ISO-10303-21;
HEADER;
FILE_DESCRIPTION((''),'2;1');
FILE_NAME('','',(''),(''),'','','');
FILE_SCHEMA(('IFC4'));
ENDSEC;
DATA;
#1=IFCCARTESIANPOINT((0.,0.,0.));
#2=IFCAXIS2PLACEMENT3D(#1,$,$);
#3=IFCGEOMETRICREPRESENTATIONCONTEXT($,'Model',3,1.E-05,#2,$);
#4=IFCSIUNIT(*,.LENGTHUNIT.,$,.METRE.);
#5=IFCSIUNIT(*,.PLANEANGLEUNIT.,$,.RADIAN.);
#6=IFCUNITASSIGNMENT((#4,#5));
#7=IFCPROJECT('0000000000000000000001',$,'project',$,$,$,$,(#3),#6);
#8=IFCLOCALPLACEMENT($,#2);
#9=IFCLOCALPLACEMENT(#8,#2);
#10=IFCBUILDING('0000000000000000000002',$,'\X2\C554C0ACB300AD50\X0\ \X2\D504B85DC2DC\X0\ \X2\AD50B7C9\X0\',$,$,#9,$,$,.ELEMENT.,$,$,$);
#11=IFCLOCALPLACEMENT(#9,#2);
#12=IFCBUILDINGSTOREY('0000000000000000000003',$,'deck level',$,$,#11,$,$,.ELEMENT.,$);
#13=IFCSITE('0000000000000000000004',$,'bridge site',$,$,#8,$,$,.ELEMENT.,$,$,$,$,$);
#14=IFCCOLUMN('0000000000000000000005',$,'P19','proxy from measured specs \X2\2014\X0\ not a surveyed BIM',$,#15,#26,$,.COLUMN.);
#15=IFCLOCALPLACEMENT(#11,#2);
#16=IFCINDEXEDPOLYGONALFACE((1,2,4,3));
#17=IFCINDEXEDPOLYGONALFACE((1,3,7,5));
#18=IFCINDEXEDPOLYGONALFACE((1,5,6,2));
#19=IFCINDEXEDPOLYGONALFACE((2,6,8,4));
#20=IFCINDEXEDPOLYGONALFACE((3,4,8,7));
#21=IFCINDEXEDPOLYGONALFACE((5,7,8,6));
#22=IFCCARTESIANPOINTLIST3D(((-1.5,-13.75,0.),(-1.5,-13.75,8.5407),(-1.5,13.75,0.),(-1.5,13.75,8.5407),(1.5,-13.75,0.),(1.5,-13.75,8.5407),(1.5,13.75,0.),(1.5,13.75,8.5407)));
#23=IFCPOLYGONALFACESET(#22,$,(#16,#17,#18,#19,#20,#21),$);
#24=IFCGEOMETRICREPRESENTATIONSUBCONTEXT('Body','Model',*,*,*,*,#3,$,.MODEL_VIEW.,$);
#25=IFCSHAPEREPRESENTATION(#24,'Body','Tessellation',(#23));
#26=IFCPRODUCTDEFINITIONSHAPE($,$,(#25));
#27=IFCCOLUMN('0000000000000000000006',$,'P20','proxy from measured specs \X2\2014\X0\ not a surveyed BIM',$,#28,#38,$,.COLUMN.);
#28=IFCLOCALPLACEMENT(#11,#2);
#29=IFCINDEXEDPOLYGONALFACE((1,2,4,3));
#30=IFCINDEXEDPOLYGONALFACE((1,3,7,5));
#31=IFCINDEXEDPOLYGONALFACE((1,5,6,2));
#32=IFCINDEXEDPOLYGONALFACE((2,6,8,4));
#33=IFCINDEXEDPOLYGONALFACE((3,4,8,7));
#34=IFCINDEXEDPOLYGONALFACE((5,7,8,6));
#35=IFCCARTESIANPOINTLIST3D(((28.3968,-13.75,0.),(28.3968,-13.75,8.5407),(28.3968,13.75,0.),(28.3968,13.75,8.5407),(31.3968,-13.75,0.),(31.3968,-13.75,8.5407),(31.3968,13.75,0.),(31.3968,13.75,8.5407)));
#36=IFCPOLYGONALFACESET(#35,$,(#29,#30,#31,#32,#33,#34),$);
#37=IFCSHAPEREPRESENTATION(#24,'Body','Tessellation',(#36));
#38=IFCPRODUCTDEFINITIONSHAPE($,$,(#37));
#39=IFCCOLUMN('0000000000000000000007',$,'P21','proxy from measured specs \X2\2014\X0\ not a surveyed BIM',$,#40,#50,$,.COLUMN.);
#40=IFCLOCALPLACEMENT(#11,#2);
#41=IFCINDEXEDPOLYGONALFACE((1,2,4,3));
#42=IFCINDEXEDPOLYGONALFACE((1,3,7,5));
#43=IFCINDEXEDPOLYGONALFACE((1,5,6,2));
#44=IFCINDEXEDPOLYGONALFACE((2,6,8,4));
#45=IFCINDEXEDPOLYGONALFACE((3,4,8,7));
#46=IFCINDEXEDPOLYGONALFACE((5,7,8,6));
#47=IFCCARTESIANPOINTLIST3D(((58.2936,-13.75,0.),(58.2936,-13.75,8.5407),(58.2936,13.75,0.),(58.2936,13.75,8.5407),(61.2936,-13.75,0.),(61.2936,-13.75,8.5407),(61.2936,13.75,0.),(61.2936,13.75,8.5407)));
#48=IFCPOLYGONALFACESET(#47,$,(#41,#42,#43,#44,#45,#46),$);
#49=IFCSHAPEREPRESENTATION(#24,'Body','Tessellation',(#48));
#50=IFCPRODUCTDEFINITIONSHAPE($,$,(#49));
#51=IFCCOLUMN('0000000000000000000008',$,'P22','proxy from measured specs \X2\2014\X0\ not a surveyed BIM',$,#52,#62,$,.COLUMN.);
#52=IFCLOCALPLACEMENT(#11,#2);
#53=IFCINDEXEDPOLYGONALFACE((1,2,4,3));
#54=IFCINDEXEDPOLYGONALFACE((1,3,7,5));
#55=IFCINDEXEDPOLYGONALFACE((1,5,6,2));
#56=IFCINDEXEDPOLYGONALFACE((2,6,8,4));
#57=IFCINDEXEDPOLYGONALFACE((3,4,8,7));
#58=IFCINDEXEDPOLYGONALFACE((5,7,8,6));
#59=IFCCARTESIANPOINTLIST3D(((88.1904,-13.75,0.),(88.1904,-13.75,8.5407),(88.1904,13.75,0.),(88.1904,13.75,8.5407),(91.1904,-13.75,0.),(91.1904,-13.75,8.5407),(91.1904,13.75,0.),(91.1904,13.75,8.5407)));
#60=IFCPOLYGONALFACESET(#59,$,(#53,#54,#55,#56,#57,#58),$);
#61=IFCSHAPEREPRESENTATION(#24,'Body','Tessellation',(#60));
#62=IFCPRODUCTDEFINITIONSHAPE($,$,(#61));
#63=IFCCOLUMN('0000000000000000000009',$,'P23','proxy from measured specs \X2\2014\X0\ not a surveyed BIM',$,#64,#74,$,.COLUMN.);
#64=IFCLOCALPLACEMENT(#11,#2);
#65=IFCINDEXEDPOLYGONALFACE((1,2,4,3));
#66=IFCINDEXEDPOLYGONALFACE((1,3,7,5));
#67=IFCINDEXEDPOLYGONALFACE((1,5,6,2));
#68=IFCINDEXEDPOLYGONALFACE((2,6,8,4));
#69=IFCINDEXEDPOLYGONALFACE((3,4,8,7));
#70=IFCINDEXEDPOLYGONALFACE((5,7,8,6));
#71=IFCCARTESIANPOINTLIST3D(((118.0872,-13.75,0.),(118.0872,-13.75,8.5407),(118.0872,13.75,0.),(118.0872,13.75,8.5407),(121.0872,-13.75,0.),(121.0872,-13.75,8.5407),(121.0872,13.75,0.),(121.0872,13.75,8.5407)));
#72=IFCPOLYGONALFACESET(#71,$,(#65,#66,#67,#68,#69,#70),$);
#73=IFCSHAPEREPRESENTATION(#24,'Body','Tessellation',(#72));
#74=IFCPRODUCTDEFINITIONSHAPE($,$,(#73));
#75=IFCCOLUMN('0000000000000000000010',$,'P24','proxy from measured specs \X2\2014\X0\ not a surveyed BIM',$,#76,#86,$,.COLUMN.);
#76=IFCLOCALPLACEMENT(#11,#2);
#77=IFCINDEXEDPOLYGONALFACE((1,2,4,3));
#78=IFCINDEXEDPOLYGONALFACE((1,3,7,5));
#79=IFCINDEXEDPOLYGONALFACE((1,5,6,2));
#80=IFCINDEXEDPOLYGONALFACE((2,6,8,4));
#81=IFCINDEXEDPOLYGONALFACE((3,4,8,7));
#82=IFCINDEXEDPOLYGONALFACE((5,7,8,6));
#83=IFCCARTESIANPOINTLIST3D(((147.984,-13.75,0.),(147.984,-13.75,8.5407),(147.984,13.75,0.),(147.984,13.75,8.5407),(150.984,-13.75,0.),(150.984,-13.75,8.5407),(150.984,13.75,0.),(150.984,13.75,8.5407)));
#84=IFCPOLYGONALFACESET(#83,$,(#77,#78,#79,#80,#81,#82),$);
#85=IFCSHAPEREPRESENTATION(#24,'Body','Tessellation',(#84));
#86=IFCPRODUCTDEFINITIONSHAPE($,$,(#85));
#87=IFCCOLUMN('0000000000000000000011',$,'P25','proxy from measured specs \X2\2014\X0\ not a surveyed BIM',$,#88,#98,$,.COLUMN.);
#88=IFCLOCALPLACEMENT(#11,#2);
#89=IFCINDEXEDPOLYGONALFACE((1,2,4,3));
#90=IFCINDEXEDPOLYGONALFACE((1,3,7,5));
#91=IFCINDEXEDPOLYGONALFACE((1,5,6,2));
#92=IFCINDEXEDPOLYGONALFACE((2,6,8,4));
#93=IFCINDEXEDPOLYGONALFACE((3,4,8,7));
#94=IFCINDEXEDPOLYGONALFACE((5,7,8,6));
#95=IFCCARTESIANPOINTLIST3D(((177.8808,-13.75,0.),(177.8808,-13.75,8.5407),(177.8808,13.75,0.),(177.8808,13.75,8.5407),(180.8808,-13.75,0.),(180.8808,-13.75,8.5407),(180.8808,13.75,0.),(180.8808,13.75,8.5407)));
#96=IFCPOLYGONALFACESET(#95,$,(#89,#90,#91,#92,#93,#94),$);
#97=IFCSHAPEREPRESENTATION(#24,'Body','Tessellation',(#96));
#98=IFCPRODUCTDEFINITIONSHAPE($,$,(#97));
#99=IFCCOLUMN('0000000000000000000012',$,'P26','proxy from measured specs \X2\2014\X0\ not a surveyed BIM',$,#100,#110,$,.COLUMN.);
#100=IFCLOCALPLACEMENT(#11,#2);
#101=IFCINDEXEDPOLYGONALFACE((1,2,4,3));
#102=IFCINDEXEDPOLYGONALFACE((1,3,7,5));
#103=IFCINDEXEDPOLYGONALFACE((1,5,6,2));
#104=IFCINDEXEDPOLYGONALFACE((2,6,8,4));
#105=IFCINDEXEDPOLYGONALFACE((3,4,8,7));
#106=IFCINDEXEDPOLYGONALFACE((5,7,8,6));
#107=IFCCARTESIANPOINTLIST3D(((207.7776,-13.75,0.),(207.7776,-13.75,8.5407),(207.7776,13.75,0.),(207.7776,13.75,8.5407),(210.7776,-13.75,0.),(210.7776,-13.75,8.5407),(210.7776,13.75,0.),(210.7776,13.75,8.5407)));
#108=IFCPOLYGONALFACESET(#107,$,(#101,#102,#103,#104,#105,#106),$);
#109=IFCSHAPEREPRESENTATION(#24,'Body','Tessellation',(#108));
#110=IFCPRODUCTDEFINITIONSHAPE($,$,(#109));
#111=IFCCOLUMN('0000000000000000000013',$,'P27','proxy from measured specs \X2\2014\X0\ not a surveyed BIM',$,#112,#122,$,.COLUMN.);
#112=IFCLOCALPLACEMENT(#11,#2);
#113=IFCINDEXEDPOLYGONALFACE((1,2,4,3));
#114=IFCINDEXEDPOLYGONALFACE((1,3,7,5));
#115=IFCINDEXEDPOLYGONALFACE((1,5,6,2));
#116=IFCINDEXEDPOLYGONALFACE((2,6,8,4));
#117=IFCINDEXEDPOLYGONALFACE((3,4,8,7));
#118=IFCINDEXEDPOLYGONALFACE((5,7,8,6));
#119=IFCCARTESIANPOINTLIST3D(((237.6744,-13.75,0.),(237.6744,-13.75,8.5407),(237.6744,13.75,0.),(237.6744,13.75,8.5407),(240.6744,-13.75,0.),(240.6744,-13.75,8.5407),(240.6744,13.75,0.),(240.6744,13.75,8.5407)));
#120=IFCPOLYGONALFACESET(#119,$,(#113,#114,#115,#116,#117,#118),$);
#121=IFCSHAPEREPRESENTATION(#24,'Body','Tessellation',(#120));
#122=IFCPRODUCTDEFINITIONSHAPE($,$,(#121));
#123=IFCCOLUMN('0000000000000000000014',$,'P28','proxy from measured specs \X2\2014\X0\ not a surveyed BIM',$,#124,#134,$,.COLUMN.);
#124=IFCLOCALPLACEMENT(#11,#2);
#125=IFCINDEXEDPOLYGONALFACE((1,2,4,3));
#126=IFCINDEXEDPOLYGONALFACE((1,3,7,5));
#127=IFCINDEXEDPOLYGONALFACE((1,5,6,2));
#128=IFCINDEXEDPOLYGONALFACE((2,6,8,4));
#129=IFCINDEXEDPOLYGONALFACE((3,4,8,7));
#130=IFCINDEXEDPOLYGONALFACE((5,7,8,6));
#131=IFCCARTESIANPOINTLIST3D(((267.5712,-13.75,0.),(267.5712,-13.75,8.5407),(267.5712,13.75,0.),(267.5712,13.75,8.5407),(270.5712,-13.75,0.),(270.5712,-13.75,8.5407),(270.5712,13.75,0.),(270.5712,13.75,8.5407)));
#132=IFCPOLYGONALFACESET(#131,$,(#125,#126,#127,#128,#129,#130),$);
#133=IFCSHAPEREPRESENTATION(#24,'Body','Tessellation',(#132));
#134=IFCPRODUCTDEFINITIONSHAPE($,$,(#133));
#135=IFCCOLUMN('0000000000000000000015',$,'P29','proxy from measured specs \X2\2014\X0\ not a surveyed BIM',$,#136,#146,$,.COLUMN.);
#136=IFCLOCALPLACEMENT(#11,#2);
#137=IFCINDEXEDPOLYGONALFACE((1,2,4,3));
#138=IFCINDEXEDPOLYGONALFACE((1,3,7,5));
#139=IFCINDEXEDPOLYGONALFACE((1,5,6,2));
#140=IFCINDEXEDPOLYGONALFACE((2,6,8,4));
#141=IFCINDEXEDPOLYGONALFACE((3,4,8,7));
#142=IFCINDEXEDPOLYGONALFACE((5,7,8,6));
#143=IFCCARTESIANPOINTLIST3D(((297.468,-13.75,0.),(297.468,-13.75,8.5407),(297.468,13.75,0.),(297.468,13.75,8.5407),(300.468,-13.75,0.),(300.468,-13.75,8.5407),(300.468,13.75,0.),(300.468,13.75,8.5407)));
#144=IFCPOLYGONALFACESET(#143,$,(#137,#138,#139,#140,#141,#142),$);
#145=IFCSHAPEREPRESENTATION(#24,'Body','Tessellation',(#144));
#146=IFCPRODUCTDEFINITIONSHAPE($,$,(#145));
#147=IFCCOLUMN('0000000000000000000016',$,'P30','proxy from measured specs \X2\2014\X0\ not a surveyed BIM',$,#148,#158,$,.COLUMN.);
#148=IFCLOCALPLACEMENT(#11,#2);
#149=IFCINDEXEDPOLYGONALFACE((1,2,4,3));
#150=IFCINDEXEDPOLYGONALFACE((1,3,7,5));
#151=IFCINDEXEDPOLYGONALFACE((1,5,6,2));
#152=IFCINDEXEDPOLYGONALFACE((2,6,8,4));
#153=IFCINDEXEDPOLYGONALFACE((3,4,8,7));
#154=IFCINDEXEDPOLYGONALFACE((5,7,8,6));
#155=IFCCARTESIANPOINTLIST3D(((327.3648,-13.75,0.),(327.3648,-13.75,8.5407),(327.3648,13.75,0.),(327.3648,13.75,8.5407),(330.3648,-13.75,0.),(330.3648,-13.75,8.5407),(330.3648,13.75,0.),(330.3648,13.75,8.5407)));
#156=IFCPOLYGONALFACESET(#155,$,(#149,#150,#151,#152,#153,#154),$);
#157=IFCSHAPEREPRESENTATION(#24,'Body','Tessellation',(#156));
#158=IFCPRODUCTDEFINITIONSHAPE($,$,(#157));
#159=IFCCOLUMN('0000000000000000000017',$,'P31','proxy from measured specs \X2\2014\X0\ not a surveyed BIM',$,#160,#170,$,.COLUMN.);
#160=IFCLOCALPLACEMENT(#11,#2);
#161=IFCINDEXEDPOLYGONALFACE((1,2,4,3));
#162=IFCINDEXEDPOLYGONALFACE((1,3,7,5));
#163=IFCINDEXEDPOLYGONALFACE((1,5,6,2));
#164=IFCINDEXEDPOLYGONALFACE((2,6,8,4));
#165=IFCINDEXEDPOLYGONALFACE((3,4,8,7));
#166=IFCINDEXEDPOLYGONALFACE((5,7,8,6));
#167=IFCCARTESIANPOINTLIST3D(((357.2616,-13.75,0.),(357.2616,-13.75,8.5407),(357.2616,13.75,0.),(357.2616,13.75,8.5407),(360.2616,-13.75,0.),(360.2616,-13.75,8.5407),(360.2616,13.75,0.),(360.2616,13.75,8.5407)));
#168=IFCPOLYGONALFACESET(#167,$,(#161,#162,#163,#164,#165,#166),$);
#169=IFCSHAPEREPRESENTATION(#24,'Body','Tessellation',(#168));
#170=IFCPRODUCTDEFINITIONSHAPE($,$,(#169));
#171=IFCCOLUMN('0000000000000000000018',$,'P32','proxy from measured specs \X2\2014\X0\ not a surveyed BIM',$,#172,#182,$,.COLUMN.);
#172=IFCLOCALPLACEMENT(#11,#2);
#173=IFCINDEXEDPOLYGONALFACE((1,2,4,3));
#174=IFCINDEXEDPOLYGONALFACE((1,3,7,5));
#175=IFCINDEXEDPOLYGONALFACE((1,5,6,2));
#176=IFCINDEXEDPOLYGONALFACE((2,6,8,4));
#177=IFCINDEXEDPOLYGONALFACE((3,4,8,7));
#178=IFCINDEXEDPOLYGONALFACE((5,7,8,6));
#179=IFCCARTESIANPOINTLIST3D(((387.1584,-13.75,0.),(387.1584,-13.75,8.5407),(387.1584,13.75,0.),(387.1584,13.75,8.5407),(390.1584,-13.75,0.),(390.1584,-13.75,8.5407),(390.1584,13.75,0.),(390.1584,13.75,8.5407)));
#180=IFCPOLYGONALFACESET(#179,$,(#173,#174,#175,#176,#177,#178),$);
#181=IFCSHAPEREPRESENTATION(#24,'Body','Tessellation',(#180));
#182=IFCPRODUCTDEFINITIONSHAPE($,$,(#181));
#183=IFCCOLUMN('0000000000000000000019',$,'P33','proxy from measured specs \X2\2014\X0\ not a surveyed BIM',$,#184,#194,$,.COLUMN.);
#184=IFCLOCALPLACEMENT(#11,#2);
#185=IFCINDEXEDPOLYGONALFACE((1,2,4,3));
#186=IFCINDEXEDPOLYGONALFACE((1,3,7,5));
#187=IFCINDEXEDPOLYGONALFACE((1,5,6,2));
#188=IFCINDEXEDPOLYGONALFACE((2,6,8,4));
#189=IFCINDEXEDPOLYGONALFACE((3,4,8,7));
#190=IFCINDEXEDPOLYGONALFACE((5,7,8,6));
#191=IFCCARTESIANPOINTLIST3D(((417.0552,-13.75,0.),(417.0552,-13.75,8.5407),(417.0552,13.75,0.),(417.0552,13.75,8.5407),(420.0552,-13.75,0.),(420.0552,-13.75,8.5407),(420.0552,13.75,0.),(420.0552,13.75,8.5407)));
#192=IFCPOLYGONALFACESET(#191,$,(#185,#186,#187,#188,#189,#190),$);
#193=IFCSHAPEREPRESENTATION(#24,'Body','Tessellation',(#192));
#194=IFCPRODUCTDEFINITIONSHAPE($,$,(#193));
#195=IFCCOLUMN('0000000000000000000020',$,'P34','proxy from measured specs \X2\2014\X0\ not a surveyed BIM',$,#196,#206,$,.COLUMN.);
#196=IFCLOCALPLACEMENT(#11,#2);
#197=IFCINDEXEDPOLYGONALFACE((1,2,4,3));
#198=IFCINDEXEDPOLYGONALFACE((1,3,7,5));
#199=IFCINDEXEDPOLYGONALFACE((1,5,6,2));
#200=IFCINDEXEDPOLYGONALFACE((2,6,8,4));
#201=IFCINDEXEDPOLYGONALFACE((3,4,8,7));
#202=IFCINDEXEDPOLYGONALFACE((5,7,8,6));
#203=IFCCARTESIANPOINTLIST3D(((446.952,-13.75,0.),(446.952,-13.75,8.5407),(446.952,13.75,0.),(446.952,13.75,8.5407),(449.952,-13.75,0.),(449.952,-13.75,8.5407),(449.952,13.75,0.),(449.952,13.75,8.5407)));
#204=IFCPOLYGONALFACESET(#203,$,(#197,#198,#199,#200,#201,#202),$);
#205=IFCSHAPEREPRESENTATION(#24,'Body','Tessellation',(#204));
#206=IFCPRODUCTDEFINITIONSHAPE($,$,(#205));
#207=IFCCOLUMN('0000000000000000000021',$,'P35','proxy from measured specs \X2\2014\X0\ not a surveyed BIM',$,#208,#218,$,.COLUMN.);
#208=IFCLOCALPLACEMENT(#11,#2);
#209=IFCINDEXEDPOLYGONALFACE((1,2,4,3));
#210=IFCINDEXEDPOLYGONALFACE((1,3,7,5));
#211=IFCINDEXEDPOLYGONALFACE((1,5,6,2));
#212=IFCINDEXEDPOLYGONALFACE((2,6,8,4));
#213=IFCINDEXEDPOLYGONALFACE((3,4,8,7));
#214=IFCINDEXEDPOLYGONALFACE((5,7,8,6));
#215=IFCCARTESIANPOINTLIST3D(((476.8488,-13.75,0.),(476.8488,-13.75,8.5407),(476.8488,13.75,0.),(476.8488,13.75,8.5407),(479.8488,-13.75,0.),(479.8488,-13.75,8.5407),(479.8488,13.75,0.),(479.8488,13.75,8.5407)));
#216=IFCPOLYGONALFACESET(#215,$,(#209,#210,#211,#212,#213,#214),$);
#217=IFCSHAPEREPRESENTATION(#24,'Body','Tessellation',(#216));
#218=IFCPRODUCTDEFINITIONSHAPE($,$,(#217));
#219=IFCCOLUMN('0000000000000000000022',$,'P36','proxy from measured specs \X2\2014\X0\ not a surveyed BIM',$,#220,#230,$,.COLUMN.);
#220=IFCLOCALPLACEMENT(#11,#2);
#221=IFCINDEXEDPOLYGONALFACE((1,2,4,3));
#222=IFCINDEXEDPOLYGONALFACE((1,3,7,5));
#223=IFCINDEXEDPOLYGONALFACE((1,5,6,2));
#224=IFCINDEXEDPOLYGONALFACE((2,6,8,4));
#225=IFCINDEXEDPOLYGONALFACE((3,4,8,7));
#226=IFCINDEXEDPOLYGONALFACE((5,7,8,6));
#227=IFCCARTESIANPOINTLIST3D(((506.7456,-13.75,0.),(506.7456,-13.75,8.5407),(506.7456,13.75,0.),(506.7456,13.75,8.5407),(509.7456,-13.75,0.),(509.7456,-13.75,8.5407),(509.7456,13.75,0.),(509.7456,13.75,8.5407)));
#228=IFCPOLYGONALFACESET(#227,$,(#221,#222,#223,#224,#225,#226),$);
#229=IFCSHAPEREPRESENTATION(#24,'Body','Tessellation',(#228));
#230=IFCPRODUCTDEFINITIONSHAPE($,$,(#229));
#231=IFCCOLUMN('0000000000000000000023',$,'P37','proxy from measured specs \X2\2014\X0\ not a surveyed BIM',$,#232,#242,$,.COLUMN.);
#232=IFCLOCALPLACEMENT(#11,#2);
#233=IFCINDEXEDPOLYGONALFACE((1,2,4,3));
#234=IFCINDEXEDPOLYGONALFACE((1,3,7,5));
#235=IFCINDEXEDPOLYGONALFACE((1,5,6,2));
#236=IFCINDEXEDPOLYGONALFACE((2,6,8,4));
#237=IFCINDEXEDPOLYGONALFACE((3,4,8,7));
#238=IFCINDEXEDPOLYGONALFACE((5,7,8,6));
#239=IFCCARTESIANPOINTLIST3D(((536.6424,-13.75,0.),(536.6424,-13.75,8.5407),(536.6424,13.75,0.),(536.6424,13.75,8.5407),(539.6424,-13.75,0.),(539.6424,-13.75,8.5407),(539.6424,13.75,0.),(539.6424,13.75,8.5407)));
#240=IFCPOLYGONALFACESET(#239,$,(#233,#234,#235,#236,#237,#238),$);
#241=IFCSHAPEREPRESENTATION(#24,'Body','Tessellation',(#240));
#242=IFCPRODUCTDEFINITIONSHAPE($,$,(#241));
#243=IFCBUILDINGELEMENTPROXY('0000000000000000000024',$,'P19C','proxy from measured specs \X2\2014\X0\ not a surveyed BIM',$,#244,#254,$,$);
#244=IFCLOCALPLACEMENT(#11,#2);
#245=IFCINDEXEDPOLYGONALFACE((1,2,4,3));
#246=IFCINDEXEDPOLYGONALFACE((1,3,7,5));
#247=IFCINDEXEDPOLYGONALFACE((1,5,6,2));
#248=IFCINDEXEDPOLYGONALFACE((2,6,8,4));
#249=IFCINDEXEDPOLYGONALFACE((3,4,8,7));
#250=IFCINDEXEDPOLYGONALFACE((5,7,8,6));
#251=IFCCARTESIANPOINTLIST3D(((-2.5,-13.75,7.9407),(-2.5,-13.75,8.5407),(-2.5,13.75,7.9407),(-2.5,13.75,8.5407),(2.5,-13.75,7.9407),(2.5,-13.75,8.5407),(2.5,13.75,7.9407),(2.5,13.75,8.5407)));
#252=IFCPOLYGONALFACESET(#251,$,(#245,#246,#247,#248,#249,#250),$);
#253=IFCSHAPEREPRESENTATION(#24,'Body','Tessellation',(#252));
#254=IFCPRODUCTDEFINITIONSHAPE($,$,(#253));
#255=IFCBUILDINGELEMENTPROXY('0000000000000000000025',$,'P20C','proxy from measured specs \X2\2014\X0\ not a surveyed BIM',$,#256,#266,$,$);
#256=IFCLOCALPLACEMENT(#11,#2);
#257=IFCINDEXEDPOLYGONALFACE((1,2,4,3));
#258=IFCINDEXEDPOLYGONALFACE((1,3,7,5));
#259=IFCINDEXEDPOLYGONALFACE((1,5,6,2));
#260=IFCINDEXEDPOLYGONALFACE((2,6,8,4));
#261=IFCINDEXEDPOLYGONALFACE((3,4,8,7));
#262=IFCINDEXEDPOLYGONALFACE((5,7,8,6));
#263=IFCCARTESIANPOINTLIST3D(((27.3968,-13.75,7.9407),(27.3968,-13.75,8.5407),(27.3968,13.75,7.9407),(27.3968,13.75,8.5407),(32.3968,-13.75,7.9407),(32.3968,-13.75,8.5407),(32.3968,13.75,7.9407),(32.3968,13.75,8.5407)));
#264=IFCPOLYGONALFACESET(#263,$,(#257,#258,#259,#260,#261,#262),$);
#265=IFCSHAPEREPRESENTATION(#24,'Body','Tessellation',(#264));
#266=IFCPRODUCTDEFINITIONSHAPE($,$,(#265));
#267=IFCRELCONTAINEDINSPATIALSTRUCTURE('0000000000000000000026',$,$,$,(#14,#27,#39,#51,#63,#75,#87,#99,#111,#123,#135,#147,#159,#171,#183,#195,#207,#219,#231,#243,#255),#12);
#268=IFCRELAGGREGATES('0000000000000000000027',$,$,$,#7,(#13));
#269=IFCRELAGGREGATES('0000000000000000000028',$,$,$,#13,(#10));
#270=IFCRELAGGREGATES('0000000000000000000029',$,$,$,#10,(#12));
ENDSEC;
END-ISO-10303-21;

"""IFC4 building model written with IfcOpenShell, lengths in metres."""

from ifc_helpers import new_model, si_unit, frame, origin, origin_2d, place, context, subcontext, project, spatial, rectangle, extrude, element, save


model = new_model("IFC4")

# Units and contexts
model_context = context("Model", 3, precision=1e-05, world=origin())
body_context = subcontext(model_context, "Body", "Model", "MODEL_VIEW")
ifc_project = project(units=[si_unit("LENGTHUNIT", "METRE"), si_unit("PLANEANGLEUNIT", "RADIAN")], contexts=[model_context])

# Site, building, storey
site_placement = place(None, origin())
site = spatial("IfcSite", under=ifc_project, at=site_placement, Name="bridge site", CompositionType="ELEMENT")
building_placement = place(site_placement, origin())
building = spatial("IfcBuilding", under=site, at=building_placement, Name="암사대교 프록시 교량", CompositionType="ELEMENT")
storey_placement = place(building_placement, origin())
storey = spatial("IfcBuildingStorey", under=building, at=storey_placement, Name="deck level", CompositionType="ELEMENT")

# Columns
for number, where, name in (
    (1, (0.0, 0.0, 0.0), "P19"),
    (2, (29.8968, 0.0, 0.0), "P20"),
    (3, (59.7936, 0.0, 0.0), "P21"),
    (4, (89.6904, 0.0, 0.0), "P22"),
    (5, (119.5872, 0.0, 0.0), "P23"),
    (6, (149.484, 0.0, 0.0), "P24"),
    (7, (179.3808, 0.0, 0.0), "P25"),
    (8, (209.2776, 0.0, 0.0), "P26"),
    (9, (239.1744, 0.0, 0.0), "P27"),
    (10, (269.0712, 0.0, 0.0), "P28"),
    (11, (298.968, 0.0, 0.0), "P29"),
    (12, (328.8648, 0.0, 0.0), "P30"),
    (13, (358.7616, 0.0, 0.0), "P31"),
    (14, (388.6584, 0.0, 0.0), "P32"),
    (15, (418.5552, 0.0, 0.0), "P33"),
    (16, (448.452, 0.0, 0.0), "P34"),
    (17, (478.3488, 0.0, 0.0), "P35"),
    (18, (508.2456, 0.0, 0.0), "P36"),
    (19, (538.1424, 0.0, 0.0), "P37"),
):
    element("IfcColumn", number, at=place(storey_placement, frame(where)), inside=storey, Name=name, Description="proxy from measured specs — not a surveyed BIM", PredefinedType="COLUMN", context=body_context, shape_type="SweptSolid", body=[
        extrude(rectangle(XDim=3.0, YDim=27.5, at=origin_2d()), origin(), (0.0, 0.0, 1.0), 8.5407),
    ])

# Building element proxies
for number, where, name in (
    (20, (0.0, 0.0, 7.9407), "P19C"),
    (21, (29.8968, 0.0, 7.9407), "P20C"),
):
    element("IfcBuildingElementProxy", number, at=place(storey_placement, frame(where)), inside=storey, Name=name, Description="proxy from measured specs — not a surveyed BIM", context=body_context, shape_type="SweptSolid", body=[
        extrude(rectangle(XDim=5.0, YDim=27.5, at=origin_2d()), origin(), (0.0, 0.0, 1.0), 0.6),
    ])

save(model, "model.ifc")
